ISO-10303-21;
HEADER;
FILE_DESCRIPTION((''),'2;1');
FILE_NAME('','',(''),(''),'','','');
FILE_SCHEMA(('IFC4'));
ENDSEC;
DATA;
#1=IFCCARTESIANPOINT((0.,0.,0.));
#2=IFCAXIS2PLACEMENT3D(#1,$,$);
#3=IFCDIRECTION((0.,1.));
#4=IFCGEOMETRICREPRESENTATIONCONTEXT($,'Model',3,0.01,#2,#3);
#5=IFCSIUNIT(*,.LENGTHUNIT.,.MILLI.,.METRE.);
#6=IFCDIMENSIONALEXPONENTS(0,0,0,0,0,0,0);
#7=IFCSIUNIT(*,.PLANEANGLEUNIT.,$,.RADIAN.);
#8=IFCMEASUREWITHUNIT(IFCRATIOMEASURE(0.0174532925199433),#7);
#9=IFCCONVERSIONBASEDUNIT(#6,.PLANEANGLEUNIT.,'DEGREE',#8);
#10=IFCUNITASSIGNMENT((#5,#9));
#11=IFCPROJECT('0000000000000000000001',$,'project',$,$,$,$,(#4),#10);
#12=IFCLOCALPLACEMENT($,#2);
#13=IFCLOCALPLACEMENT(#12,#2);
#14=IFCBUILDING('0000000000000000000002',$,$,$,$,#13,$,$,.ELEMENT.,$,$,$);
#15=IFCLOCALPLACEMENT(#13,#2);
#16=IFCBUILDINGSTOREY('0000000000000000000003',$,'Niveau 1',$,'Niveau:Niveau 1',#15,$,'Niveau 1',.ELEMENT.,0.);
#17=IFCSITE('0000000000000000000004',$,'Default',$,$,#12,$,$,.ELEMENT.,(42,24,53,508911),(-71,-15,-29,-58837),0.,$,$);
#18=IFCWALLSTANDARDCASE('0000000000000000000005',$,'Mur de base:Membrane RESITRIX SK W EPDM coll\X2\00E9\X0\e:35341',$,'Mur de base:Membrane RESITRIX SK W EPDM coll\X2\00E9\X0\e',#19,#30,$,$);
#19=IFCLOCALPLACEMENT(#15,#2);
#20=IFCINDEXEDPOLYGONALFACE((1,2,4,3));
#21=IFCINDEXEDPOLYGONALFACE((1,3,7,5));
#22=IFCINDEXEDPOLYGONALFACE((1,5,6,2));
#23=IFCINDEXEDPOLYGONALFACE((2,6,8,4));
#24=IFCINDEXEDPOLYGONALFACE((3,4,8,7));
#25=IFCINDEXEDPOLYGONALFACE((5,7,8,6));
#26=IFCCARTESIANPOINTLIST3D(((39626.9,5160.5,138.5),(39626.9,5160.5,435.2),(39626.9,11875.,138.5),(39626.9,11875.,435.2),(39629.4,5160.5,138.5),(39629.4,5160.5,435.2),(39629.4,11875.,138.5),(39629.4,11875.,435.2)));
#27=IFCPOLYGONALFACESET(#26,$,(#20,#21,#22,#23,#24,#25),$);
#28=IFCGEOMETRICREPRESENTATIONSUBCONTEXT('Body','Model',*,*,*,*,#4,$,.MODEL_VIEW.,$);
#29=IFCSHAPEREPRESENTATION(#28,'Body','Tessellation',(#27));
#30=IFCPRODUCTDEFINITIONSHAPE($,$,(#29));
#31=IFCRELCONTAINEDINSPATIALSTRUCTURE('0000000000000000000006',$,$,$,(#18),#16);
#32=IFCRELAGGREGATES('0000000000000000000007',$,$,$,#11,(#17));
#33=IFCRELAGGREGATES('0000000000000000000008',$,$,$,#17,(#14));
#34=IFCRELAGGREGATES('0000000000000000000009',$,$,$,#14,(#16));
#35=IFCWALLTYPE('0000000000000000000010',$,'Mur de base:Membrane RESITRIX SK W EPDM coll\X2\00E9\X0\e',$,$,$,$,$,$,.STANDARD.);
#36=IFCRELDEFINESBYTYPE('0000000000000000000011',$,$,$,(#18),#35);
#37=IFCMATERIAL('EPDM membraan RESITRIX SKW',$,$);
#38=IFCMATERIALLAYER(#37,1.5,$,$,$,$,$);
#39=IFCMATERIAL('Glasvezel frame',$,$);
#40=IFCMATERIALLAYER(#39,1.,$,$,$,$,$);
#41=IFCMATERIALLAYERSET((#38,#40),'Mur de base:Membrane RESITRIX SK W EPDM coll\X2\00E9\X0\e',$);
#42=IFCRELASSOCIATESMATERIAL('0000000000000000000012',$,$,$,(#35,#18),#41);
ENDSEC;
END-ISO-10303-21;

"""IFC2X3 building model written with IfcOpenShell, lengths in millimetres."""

from ifc_helpers import new_model, entity, si_unit, converted_unit, direction, frame, frame_2d, origin, place, context, subcontext, project, spatial, rectangle, extrude, material, layer, layer_set, layer_usage, type_object, element, save


model = new_model("IFC2X3")

# Units and contexts
model_context = context("Model", 3, precision=0.01, world=origin(), true_north=direction((0.0, 1.0)))
body_context = subcontext(model_context, "Body", "Model", "MODEL_VIEW")
ifc_project = project(units=[si_unit("LENGTHUNIT", "METRE", prefix="MILLI"), converted_unit("PLANEANGLEUNIT", "DEGREE", entity("IfcRatioMeasure", 0.0174532925199433), si_unit("PLANEANGLEUNIT", "RADIAN"), dimensions=[0, 0, 0, 0, 0, 0, 0])], contexts=[model_context])

# Site, building, storey
site_placement = place(None, origin())
site = spatial("IfcSite", under=ifc_project, at=site_placement, Name="Default", CompositionType="ELEMENT", RefLatitude=(42, 24, 53, 508911), RefLongitude=(-71, -15, -29, -58837), RefElevation=0.0)
building_placement = place(site_placement, origin())
building = spatial("IfcBuilding", under=site, at=building_placement, CompositionType="ELEMENT")
storey_placement = place(building_placement, origin())
storey = spatial("IfcBuildingStorey", under=building, at=storey_placement, Name="Niveau 1", ObjectType="Niveau:Niveau 1", LongName="Niveau 1", CompositionType="ELEMENT", Elevation=0.0)

# Shared definitions
ifc_material_1 = material(Name="EPDM membraan RESITRIX SKW")
ifc_material_2 = material(Name="Glasvezel frame")

# Wall
ifc_layer_1 = layer(ifc_material_1, 1.5)
ifc_layer_2 = layer(ifc_material_2, 1.0)
ifc_layer_set_1 = layer_set([ifc_layer_1, ifc_layer_2], Name="Mur de base:Membrane RESITRIX SK W EPDM collée")
ifc_layer_usage_1 = layer_usage(ifc_layer_set_1, "AXIS2", "NEGATIVE", 1.2)
wall_type_1 = type_object("IfcWallType", Name="Mur de base:Membrane RESITRIX SK W EPDM collée", PredefinedType="STANDARD", material=ifc_layer_set_1)
wall_1_placement = place(storey_placement, frame((39628.2, 11875.0, 138.5), z_axis=(0.0, 0.0, 1.0), x_axis=(0.0, -1.0, 0.0)))
element("IfcWallStandardCase", 1, at=wall_1_placement, inside=storey, type_object=wall_type_1, material=ifc_layer_usage_1, Name="Mur de base:Membrane RESITRIX SK W EPDM collée:35341", ObjectType="Mur de base:Membrane RESITRIX SK W EPDM collée", context=body_context, shape_type="SweptSolid", body=[
    extrude(rectangle(XDim=6714.5, YDim=2.5, at=frame_2d((3357.2, 0.0), x_axis=(-1.0, 0.0))), origin(), (0.0, 0.0, 1.0), 296.7),
])

save(model, "model.ifc")
